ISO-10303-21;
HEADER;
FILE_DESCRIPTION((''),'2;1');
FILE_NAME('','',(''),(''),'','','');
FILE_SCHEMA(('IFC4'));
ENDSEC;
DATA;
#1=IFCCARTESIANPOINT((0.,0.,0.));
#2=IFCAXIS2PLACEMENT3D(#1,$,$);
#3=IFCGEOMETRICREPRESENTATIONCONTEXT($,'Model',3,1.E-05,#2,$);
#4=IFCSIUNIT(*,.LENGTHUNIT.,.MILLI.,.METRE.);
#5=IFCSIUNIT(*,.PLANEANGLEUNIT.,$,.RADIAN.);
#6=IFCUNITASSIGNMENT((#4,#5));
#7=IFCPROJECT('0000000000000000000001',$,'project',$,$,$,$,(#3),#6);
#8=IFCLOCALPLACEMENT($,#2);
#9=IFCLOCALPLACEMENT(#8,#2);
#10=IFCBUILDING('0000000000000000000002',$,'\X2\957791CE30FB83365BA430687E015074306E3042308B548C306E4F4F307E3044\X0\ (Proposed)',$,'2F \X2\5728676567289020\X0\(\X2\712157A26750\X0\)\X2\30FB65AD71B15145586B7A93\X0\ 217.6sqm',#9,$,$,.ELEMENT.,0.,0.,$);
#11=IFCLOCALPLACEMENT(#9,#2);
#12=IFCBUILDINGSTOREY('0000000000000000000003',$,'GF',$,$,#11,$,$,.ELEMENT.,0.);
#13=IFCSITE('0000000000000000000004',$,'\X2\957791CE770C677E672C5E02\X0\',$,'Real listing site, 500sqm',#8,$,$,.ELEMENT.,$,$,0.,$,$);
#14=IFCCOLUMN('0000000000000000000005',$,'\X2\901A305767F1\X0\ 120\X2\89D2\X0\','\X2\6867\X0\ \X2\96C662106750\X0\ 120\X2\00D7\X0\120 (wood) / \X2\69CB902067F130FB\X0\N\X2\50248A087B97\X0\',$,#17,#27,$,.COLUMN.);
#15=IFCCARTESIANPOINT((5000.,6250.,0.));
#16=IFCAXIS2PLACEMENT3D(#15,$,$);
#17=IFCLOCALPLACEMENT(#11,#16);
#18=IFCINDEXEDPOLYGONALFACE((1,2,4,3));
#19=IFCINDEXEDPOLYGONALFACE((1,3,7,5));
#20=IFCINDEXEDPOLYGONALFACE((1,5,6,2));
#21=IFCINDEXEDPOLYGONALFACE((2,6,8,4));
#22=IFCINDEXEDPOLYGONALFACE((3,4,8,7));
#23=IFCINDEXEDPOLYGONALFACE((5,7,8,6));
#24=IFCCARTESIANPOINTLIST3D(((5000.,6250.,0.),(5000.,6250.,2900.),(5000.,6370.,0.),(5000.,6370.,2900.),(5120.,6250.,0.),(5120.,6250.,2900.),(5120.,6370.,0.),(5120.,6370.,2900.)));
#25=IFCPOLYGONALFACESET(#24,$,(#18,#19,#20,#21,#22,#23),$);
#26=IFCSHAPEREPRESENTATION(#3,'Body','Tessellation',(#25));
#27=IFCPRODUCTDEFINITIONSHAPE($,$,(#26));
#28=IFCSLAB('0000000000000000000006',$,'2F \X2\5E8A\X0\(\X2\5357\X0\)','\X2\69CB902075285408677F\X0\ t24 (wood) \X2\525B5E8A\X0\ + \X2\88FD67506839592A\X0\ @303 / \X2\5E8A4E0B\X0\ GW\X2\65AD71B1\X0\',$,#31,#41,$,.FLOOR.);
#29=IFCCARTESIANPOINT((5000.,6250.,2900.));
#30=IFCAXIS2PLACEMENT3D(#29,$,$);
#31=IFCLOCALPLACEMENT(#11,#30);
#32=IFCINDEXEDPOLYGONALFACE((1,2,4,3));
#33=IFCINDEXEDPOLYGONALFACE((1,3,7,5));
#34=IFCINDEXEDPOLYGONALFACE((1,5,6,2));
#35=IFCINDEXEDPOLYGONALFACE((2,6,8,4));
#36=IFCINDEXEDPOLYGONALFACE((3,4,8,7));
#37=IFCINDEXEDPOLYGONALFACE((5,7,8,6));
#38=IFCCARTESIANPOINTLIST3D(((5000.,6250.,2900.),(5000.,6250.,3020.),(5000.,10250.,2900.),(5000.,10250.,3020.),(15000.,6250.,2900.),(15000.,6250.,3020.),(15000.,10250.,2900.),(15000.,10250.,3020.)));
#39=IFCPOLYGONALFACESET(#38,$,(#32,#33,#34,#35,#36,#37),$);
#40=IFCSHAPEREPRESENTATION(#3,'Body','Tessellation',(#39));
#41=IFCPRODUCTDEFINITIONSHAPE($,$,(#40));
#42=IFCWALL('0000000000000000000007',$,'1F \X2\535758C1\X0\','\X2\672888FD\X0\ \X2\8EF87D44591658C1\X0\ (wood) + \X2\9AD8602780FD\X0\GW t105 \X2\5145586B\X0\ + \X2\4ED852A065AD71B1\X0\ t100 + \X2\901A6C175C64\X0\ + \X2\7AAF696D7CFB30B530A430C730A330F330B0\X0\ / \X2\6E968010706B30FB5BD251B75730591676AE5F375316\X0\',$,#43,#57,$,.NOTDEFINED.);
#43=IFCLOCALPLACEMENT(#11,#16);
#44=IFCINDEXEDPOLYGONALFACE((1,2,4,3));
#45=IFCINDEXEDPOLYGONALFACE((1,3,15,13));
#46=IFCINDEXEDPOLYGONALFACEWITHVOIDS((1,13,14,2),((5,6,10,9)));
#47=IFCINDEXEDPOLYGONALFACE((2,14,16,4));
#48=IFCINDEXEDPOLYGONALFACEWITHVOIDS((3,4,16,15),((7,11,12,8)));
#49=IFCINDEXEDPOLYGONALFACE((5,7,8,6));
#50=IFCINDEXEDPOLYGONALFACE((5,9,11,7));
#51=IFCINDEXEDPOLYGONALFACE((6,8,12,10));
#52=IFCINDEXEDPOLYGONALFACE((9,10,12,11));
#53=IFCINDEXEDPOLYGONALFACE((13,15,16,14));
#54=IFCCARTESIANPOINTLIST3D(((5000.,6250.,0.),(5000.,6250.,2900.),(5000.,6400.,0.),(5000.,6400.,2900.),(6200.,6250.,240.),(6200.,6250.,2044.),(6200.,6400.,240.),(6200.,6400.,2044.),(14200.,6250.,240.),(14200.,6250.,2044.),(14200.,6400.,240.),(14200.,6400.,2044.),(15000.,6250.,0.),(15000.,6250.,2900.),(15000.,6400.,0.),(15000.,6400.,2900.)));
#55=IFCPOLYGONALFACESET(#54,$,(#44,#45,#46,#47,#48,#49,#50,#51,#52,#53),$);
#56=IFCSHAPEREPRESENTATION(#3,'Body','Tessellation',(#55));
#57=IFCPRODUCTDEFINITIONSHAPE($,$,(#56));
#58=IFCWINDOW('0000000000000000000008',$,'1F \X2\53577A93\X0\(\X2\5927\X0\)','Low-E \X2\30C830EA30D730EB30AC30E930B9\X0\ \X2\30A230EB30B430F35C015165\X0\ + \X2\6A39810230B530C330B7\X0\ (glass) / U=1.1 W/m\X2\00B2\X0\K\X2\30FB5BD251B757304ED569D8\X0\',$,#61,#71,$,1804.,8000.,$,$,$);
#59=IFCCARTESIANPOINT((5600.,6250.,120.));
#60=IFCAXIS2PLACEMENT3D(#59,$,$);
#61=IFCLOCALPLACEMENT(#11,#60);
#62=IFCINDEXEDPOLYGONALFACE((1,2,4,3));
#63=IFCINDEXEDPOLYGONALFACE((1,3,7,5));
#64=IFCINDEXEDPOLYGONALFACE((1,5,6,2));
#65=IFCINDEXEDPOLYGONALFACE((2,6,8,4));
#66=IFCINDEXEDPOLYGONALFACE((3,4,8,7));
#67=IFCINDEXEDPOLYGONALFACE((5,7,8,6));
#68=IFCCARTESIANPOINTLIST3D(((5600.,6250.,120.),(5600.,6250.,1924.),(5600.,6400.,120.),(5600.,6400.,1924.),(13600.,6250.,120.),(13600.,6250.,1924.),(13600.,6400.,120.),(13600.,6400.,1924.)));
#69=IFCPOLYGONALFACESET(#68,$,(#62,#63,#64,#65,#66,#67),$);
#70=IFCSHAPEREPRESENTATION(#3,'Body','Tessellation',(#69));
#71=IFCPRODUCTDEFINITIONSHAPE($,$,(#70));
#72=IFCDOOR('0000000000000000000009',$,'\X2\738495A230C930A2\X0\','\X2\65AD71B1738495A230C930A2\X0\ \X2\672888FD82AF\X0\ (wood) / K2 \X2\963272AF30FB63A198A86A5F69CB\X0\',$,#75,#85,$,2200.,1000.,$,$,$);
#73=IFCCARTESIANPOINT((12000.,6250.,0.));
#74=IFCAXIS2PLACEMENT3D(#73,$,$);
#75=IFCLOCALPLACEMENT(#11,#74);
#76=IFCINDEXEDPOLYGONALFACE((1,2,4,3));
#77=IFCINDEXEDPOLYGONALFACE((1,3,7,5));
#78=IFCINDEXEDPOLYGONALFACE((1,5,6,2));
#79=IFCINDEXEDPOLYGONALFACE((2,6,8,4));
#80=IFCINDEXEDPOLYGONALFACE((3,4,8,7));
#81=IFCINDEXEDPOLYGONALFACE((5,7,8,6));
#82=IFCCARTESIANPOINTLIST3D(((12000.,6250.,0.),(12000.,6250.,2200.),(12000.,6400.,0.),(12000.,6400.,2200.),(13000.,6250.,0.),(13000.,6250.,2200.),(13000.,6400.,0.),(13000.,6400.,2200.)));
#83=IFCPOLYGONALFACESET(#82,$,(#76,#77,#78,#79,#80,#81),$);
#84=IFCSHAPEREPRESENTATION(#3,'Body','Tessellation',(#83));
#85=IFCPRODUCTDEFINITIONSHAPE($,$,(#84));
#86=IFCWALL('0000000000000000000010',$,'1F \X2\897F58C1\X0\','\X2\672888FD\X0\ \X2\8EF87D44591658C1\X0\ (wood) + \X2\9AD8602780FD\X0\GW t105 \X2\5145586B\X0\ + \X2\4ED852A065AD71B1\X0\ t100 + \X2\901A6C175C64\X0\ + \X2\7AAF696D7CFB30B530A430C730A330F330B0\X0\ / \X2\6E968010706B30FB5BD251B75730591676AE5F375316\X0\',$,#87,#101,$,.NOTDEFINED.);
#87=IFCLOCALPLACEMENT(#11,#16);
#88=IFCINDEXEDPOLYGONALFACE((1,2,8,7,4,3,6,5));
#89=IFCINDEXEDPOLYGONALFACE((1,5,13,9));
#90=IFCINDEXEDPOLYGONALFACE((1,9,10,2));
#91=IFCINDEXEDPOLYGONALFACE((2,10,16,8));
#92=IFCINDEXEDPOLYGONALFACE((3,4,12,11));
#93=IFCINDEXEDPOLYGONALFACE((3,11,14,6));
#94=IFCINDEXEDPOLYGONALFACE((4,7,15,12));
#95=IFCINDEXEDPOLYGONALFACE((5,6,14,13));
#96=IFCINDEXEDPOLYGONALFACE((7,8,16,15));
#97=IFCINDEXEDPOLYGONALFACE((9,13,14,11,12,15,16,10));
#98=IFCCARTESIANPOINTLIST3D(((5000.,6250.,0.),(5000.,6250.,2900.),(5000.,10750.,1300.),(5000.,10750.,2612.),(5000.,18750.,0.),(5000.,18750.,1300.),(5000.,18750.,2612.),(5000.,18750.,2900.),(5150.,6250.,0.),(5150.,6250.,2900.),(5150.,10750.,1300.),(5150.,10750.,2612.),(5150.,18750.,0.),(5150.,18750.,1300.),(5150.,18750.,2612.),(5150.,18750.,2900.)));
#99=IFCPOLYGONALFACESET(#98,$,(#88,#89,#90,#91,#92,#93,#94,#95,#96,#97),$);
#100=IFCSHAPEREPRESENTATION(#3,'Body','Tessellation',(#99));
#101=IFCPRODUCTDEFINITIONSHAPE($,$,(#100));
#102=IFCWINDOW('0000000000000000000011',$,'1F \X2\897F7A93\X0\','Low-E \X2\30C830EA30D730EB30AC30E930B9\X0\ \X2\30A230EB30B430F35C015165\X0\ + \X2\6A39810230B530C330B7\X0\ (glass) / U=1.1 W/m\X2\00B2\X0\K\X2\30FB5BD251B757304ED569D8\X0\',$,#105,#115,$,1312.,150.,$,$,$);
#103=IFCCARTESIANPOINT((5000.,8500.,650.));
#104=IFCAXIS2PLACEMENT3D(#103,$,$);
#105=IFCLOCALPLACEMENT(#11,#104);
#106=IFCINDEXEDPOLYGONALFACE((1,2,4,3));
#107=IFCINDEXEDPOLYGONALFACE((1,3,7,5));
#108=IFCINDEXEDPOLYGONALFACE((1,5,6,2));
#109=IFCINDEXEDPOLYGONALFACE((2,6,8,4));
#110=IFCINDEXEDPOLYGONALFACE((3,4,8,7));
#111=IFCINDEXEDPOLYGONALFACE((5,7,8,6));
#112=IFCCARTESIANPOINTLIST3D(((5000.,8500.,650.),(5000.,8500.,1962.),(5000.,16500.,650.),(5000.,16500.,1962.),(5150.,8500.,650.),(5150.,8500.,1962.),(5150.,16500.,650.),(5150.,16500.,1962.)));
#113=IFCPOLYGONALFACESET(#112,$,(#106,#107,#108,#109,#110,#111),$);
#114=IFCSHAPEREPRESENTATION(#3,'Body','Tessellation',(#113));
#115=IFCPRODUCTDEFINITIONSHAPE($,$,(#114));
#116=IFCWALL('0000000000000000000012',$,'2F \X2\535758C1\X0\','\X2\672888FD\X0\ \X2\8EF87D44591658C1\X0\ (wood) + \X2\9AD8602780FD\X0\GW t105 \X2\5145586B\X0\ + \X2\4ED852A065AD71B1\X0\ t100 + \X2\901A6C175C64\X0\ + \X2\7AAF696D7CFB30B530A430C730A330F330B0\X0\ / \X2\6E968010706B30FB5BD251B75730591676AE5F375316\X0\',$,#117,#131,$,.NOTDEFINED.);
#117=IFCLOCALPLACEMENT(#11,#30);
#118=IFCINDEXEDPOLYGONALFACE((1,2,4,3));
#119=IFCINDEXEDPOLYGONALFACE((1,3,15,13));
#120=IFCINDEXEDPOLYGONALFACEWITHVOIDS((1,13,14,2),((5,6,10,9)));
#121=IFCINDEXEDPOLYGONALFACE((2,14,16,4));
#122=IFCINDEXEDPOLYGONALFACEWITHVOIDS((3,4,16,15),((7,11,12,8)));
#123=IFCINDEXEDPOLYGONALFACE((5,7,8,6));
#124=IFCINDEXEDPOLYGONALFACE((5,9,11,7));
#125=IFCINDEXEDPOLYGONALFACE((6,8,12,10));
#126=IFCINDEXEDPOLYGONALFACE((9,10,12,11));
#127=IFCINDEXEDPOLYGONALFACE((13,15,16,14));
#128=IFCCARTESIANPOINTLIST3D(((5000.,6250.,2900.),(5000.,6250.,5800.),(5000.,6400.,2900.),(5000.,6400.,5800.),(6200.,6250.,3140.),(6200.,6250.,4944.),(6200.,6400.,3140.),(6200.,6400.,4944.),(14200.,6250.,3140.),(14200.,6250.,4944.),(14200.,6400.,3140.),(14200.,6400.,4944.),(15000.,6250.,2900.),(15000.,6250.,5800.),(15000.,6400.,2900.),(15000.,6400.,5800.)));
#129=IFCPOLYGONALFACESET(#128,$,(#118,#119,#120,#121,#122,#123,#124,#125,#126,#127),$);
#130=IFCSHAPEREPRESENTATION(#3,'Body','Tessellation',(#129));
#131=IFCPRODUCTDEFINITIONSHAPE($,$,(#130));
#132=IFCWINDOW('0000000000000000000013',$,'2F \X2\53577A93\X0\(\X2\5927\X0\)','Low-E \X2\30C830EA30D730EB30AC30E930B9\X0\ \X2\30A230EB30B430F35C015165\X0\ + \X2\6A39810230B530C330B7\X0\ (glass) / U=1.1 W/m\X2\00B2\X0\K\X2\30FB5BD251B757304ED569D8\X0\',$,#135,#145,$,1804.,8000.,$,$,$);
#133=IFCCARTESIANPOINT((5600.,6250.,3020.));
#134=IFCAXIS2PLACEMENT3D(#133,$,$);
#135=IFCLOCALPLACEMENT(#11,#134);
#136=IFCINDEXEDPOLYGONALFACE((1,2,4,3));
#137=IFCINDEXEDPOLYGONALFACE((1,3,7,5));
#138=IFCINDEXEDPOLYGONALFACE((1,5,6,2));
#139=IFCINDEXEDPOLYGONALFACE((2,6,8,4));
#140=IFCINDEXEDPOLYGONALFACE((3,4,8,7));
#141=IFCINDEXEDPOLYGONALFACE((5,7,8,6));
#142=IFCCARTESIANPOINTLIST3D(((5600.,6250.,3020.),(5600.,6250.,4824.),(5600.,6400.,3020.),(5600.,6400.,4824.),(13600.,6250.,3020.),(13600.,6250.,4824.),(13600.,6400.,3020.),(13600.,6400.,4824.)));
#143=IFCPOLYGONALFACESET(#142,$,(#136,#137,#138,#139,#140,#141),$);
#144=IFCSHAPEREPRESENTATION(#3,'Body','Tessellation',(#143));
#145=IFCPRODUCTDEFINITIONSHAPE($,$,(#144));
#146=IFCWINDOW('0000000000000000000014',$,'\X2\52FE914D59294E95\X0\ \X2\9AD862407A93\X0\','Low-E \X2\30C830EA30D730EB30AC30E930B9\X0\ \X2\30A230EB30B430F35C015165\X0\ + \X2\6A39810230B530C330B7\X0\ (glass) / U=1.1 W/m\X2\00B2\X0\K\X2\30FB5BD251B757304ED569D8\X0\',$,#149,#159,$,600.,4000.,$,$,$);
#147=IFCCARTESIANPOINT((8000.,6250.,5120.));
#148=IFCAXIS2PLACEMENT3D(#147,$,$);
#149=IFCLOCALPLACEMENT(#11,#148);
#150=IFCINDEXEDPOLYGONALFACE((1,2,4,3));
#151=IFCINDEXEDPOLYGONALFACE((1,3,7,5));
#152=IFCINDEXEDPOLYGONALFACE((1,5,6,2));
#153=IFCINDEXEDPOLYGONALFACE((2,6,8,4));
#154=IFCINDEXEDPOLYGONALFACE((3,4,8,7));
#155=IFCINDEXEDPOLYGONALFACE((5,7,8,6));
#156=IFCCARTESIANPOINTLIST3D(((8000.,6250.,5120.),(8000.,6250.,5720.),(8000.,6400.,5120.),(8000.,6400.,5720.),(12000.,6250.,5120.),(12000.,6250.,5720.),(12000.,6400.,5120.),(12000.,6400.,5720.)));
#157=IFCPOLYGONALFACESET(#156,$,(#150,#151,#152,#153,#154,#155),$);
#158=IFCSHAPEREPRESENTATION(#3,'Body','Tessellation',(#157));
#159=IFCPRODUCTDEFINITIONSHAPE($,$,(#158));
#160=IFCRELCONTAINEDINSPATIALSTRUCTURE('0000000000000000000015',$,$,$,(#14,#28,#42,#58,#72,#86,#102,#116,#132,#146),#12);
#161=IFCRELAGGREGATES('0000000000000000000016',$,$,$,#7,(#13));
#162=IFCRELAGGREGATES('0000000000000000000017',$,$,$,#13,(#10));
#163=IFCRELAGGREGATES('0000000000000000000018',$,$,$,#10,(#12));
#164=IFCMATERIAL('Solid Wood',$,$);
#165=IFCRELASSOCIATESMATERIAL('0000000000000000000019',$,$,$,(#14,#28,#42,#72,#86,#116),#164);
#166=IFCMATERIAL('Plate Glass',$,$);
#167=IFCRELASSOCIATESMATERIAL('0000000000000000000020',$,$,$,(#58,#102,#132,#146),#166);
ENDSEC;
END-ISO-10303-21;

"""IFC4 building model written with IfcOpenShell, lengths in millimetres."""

from ifc_helpers import new_model, si_unit, frame, frame_2d, origin, place, context, project, spatial, rectangle, extrude, material, element, fill, save


model = new_model("IFC4")

# Units and contexts
model_context = context("Model", 3, precision=1e-05, world=origin())
ifc_project = project(units=[si_unit("LENGTHUNIT", "METRE", prefix="MILLI"), si_unit("PLANEANGLEUNIT", "RADIAN")], contexts=[model_context])

# Site, building, storey
site_placement = place(None, origin())
site = spatial("IfcSite", under=ifc_project, at=site_placement, Name="長野県松本市", ObjectType="Real listing site, 500sqm", CompositionType="ELEMENT", RefElevation=0.0)
building_placement = place(site_placement, origin())
building = spatial("IfcBuilding", under=site, at=building_placement, Name="長野・茶室と縁側のある和の住まい (Proposed)", ObjectType="2F 在来木造(無垢材)・断熱充填窓 217.6sqm", CompositionType="ELEMENT", ElevationOfRefHeight=0.0, ElevationOfTerrain=0.0)
storey_placement = place(building_placement, origin())
storey = spatial("IfcBuildingStorey", under=building, at=storey_placement, Name="GF", CompositionType="ELEMENT", Elevation=0.0)

# Column
ifc_material_1 = material(Name="Solid Wood")
column_placement = place(storey_placement, frame((5000.0, 6250.0, 0.0)))
element("IfcColumn", 1, at=column_placement, inside=storey, material=ifc_material_1, Name="通し柱 120角", Description="桧 集成材 120×120 (wood) / 構造柱・N値計算", PredefinedType="COLUMN", context=model_context, shape_type="SweptSolid", body=[
    extrude(rectangle(XDim=120.0, YDim=120.0, at=frame_2d((60.0, 60.0))), frame((5000.0, 6250.0, 0.0)), (0.0, 0.0, 1.0), 2900.0),
])

# Slab
slab_1_placement = place(storey_placement, frame((5000.0, 6250.0, 2900.0)))
element("IfcSlab", 2, at=slab_1_placement, inside=storey, material=ifc_material_1, Name="2F 床(南)", Description="構造用合板 t24 (wood) 剛床 + 製材根太 @303 / 床下 GW断熱", PredefinedType="FLOOR", context=model_context, shape_type="SweptSolid", body=[
    extrude(rectangle(XDim=10000.0, YDim=4000.0, at=frame_2d((5000.0, 2000.0))), frame((5000.0, 6250.0, 2900.0)), (0.0, 0.0, 1.0), 120.0),
])

# Wall, openings, window, door
wall_1_placement = place(storey_placement, frame((5000.0, 6250.0, 0.0)))
wall_1 = element("IfcWall", 3, at=wall_1_placement, inside=storey, material=ifc_material_1, Name="1F 南壁", Description="木製 軸組外壁 (wood) + 高性能GW t105 充填 + 付加断熱 t100 + 通気層 + 窯業系サイディング / 準耐火・寒冷地外皮強化", PredefinedType="NOTDEFINED", context=model_context, shape_type="SweptSolid", body=[
    extrude(rectangle(XDim=10000.0, YDim=150.0, at=frame_2d((5000.0, 75.0))), frame((5000.0, 6250.0, 0.0)), (0.0, 0.0, 1.0), 2900.0),
])
opening_1_placement = place(storey_placement, frame((5600.0, 6250.0, 120.0)))
opening_1 = element("IfcOpeningElement", 4, at=opening_1_placement, cuts=wall_1, PredefinedType="NOTDEFINED", context=model_context, shape_type="SweptSolid", body=[
    extrude(rectangle(XDim=8000.0, YDim=150.0, at=frame_2d((4000.0, 75.0))), frame((5600.0, 6250.0, 120.0)), (0.0, 0.0, 1.0), 1804.0),
])
opening_2_placement = place(storey_placement, frame((12000.0, 6250.0, 0.0)))
opening_2 = element("IfcOpeningElement", 5, at=opening_2_placement, cuts=wall_1, PredefinedType="NOTDEFINED", context=model_context, shape_type="SweptSolid", body=[
    extrude(rectangle(XDim=1000.0, YDim=150.0, at=frame_2d((500.0, 75.0))), frame((12000.0, 6250.0, 0.0)), (0.0, 0.0, 1.0), 2200.0),
])
ifc_material_2 = material(Name="Plate Glass")
window_1_placement = place(storey_placement, frame((5600.0, 6250.0, 120.0)))
window_1 = element("IfcWindow", 6, at=window_1_placement, inside=storey, material=ifc_material_2, Name="1F 南窓(大)", Description="Low-E トリプルガラス アルゴン封入 + 樹脂サッシ (glass) / U=1.1 W/m²K・寒冷地仕様", OverallHeight=1804.0, OverallWidth=8000.0, context=model_context, shape_type="SweptSolid", body=[
    extrude(rectangle(XDim=8000.0, YDim=150.0, at=frame_2d((4000.0, 75.0))), frame((5600.0, 6250.0, 120.0)), (0.0, 0.0, 1.0), 1804.0),
])
fill(opening_1, window_1)
door_placement = place(storey_placement, frame((12000.0, 6250.0, 0.0)))
door = element("IfcDoor", 7, at=door_placement, inside=storey, material=ifc_material_1, Name="玄関ドア", Description="断熱玄関ドア 木製芯 (wood) / K2 防犯・採風機構", OverallHeight=2200.0, OverallWidth=1000.0, context=model_context, shape_type="SweptSolid", body=[
    extrude(rectangle(XDim=1000.0, YDim=150.0, at=frame_2d((500.0, 75.0))), frame((12000.0, 6250.0, 0.0)), (0.0, 0.0, 1.0), 2200.0),
])
fill(opening_2, door)

# Wall, opening, window
wall_2_placement = place(storey_placement, frame((5000.0, 6250.0, 0.0)))
wall_2 = element("IfcWall", 8, at=wall_2_placement, inside=storey, material=ifc_material_1, Name="1F 西壁", Description="木製 軸組外壁 (wood) + 高性能GW t105 充填 + 付加断熱 t100 + 通気層 + 窯業系サイディング / 準耐火・寒冷地外皮強化", PredefinedType="NOTDEFINED", context=model_context, shape_type="SweptSolid", body=[
    extrude(rectangle(XDim=150.0, YDim=12500.0, at=frame_2d((75.0, 6250.0))), frame((5000.0, 6250.0, 0.0)), (0.0, 0.0, 1.0), 2900.0),
])
opening_3_placement = place(storey_placement, frame((5000.0, 8500.0, 650.0)))
opening_3 = element("IfcOpeningElement", 9, at=opening_3_placement, cuts=wall_2, PredefinedType="NOTDEFINED", context=model_context, shape_type="SweptSolid", body=[
    extrude(rectangle(XDim=150.0, YDim=8000.0, at=frame_2d((75.0, 4000.0))), frame((5000.0, 8500.0, 650.0)), (0.0, 0.0, 1.0), 1312.0),
])
window_2_placement = place(storey_placement, frame((5000.0, 8500.0, 650.0)))
window_2 = element("IfcWindow", 10, at=window_2_placement, inside=storey, material=ifc_material_2, Name="1F 西窓", Description="Low-E トリプルガラス アルゴン封入 + 樹脂サッシ (glass) / U=1.1 W/m²K・寒冷地仕様", OverallHeight=1312.0, OverallWidth=150.0, context=model_context, shape_type="SweptSolid", body=[
    extrude(rectangle(XDim=150.0, YDim=8000.0, at=frame_2d((75.0, 4000.0))), frame((5000.0, 8500.0, 650.0)), (0.0, 0.0, 1.0), 1312.0),
])
fill(opening_3, window_2)

# Wall, openings, windows
wall_3_placement = place(storey_placement, frame((5000.0, 6250.0, 2900.0)))
wall_3 = element("IfcWall", 11, at=wall_3_placement, inside=storey, material=ifc_material_1, Name="2F 南壁", Description="木製 軸組外壁 (wood) + 高性能GW t105 充填 + 付加断熱 t100 + 通気層 + 窯業系サイディング / 準耐火・寒冷地外皮強化", PredefinedType="NOTDEFINED", context=model_context, shape_type="SweptSolid", body=[
    extrude(rectangle(XDim=10000.0, YDim=150.0, at=frame_2d((5000.0, 75.0))), frame((5000.0, 6250.0, 2900.0)), (0.0, 0.0, 1.0), 2900.0),
])
opening_4_placement = place(storey_placement, frame((5600.0, 6250.0, 3020.0)))
opening_4 = element("IfcOpeningElement", 12, at=opening_4_placement, cuts=wall_3, PredefinedType="NOTDEFINED", context=model_context, shape_type="SweptSolid", body=[
    extrude(rectangle(XDim=8000.0, YDim=150.0, at=frame_2d((4000.0, 75.0))), frame((5600.0, 6250.0, 3020.0)), (0.0, 0.0, 1.0), 1804.0),
])
opening_5_placement = place(storey_placement, frame((8000.0, 6250.0, 5120.0)))
opening_5 = element("IfcOpeningElement", 13, at=opening_5_placement, cuts=wall_3, PredefinedType="NOTDEFINED", context=model_context, shape_type="SweptSolid", body=[
    extrude(rectangle(XDim=4000.0, YDim=150.0, at=frame_2d((2000.0, 75.0))), frame((8000.0, 6250.0, 5120.0)), (0.0, 0.0, 1.0), 600.0),
])
window_3_placement = place(storey_placement, frame((5600.0, 6250.0, 3020.0)))
window_3 = element("IfcWindow", 14, at=window_3_placement, inside=storey, material=ifc_material_2, Name="2F 南窓(大)", Description="Low-E トリプルガラス アルゴン封入 + 樹脂サッシ (glass) / U=1.1 W/m²K・寒冷地仕様", OverallHeight=1804.0, OverallWidth=8000.0, context=model_context, shape_type="SweptSolid", body=[
    extrude(rectangle(XDim=8000.0, YDim=150.0, at=frame_2d((4000.0, 75.0))), frame((5600.0, 6250.0, 3020.0)), (0.0, 0.0, 1.0), 1804.0),
])
fill(opening_4, window_3)
window_4_placement = place(storey_placement, frame((8000.0, 6250.0, 5120.0)))
window_4 = element("IfcWindow", 15, at=window_4_placement, inside=storey, material=ifc_material_2, Name="勾配天井 高所窓", Description="Low-E トリプルガラス アルゴン封入 + 樹脂サッシ (glass) / U=1.1 W/m²K・寒冷地仕様", OverallHeight=600.0, OverallWidth=4000.0, context=model_context, shape_type="SweptSolid", body=[
    extrude(rectangle(XDim=4000.0, YDim=150.0, at=frame_2d((2000.0, 75.0))), frame((8000.0, 6250.0, 5120.0)), (0.0, 0.0, 1.0), 600.0),
])
fill(opening_5, window_4)

save(model, "model.ifc")
